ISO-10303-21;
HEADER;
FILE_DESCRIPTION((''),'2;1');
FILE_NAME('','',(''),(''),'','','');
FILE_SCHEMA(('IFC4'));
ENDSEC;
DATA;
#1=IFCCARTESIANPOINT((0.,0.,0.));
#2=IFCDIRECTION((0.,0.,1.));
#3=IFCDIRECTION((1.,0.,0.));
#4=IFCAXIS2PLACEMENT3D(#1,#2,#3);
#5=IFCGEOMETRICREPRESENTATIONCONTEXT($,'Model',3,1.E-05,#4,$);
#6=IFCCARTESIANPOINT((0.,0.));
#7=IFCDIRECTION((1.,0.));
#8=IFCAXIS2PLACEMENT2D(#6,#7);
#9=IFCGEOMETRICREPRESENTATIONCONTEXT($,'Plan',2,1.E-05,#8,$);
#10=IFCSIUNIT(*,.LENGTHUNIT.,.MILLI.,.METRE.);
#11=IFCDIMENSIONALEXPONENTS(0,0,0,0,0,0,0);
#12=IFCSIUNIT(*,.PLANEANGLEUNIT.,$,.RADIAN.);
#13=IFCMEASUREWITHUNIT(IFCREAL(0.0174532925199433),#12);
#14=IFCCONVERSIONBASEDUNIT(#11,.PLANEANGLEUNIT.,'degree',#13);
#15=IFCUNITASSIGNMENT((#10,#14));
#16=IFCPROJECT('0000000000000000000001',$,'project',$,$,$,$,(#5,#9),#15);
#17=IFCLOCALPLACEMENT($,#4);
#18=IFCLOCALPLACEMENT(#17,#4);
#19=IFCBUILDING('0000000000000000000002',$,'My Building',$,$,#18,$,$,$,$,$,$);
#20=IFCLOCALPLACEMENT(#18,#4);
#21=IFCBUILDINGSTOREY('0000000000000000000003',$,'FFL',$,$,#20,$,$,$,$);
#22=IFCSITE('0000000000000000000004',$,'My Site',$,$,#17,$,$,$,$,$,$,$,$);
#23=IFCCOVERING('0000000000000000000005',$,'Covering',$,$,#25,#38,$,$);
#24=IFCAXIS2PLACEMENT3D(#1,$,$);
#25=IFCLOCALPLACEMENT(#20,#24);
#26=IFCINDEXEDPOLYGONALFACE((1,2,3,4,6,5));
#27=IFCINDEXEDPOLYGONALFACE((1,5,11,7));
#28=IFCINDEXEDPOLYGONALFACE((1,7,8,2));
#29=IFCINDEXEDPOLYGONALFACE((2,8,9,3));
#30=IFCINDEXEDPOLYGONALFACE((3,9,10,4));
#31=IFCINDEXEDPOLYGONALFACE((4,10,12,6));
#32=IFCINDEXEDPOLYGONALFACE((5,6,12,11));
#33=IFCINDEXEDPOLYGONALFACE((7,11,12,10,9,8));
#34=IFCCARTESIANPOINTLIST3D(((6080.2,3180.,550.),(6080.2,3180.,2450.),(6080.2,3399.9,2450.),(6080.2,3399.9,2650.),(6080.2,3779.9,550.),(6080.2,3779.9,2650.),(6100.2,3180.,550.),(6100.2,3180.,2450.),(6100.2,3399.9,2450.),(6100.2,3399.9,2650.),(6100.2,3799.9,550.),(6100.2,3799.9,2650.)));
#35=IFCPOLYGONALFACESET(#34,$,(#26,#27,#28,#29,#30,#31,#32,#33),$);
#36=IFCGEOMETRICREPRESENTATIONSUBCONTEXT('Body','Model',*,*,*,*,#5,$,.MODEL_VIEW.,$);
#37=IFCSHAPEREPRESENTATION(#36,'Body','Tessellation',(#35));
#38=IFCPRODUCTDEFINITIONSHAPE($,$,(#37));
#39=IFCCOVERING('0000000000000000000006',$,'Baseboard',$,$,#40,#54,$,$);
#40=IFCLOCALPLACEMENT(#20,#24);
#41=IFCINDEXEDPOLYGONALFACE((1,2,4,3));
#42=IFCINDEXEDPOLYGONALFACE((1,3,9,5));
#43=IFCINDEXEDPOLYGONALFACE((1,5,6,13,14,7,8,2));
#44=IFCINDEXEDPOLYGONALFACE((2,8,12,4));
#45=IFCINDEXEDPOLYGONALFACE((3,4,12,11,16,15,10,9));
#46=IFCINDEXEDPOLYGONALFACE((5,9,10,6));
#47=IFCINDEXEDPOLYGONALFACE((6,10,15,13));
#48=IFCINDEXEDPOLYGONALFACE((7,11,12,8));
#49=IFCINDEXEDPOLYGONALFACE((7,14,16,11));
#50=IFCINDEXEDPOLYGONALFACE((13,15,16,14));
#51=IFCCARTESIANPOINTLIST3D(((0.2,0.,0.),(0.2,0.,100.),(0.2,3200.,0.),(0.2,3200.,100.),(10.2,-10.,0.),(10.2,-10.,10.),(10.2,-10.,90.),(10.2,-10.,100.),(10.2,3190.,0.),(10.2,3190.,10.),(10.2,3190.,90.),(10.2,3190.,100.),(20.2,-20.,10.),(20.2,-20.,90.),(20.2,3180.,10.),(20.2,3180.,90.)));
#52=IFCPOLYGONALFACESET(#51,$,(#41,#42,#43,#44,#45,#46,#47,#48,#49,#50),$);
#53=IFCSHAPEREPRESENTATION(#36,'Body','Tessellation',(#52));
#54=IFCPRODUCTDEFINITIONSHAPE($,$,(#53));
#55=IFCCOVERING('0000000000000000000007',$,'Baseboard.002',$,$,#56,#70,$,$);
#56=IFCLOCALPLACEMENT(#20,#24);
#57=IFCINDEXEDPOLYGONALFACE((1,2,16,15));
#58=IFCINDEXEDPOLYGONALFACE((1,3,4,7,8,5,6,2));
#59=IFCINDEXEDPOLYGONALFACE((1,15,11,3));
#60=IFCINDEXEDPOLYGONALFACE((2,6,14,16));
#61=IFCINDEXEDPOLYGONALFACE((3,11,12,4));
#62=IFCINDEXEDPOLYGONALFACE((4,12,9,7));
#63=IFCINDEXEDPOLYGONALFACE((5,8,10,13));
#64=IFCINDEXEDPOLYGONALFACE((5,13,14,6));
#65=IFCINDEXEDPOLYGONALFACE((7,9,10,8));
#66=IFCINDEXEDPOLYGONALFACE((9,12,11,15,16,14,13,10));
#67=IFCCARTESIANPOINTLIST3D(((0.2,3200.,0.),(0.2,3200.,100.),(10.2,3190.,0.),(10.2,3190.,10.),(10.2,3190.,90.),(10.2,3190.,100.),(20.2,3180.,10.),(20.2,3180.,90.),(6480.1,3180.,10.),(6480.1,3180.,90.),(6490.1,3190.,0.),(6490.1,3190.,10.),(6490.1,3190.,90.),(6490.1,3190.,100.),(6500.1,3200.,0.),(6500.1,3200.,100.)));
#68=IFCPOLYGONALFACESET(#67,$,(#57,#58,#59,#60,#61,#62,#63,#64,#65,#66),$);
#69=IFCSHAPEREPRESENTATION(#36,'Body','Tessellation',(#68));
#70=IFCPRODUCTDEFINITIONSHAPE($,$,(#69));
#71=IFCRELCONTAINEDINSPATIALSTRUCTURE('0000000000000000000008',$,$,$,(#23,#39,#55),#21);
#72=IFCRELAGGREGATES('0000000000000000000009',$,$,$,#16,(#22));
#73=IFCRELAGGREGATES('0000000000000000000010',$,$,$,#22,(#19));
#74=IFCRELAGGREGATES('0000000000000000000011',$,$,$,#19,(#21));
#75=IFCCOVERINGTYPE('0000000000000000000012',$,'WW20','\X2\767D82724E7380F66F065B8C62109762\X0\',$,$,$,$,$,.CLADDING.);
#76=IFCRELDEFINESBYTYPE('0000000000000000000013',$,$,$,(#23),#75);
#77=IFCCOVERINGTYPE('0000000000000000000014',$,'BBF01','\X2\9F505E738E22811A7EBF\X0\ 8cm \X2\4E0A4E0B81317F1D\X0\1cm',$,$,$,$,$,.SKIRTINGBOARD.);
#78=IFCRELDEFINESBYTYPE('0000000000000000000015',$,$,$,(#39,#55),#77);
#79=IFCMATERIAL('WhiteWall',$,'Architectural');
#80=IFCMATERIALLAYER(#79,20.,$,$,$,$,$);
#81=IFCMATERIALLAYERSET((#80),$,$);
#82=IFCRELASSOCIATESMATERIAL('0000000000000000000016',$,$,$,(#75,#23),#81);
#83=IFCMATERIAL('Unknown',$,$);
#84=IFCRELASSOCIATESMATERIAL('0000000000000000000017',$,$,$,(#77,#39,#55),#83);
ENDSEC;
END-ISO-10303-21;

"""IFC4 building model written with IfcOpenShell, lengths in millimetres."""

from ifc_helpers import new_model, entity, si_unit, converted_unit, frame, origin_with_axes, origin_2d_with_axis, place, context, subcontext, project, spatial, line, indexed_curve, outline, extrude, clip, halfspace, material, layer, layer_set, layer_usage, material_profile, profile_set, profile_usage, type_object, element, save


model = new_model("IFC4")

# Units and contexts
model_context = context("Model", 3, precision=1e-05, world=origin_with_axes())
plan_context = context("Plan", 2, precision=1e-05, world=origin_2d_with_axis())
body_context_1 = subcontext(model_context, "Body", "Model", "MODEL_VIEW")
ifc_project = project(units=[si_unit("LENGTHUNIT", "METRE", prefix="MILLI"), converted_unit("PLANEANGLEUNIT", "degree", entity("IfcReal", 0.0174532925199433), si_unit("PLANEANGLEUNIT", "RADIAN"), dimensions=[0, 0, 0, 0, 0, 0, 0])], contexts=[model_context, plan_context])

# Site, building, storey
site_placement = place(None, origin_with_axes())
site = spatial("IfcSite", under=ifc_project, at=site_placement, Name="My Site")
building_placement = place(site_placement, origin_with_axes())
building = spatial("IfcBuilding", under=site, at=building_placement, Name="My Building")
storey_placement = place(building_placement, origin_with_axes())
storey = spatial("IfcBuildingStorey", under=building, at=storey_placement, Name="FFL")

# Covering, opening
ifc_material_1 = material(Name="WhiteWall", Category="Architectural")
ifc_layer_1 = layer(ifc_material_1, 20.0)
ifc_layer_set_1 = layer_set([ifc_layer_1])
covering_type_1 = type_object("IfcCoveringType", Name="WW20", Description="白色乳胶漆完成面", PredefinedType="CLADDING", material=ifc_layer_set_1)
ifc_layer_usage_1 = layer_usage(ifc_layer_set_1, "AXIS2", "NEGATIVE", 0.0)
covering_1_placement = place(storey_placement, frame((6100.2, 3799.9, 550.0), z_axis=(0.0, 0.0, 1.0), x_axis=(-0.000001, -1.0, 0.0)))
covering_1 = element("IfcCovering", 1, at=covering_1_placement, inside=storey, type_object=covering_type_1, material=ifc_layer_usage_1, Name="Covering", context=body_context_1, shape_type="SweptSolid", body=[
    extrude(outline(indexed_curve([(20.0, -20.0), (0.0, 0.0), (620.0, 0.0), (620.0, -20.0)], segments=[line(1, 2, 3, 4, 1)])), origin_with_axes(), (0.0, 0.0, 1.0), 2100.0),
])
opening_1_placement = place(covering_1_placement, frame((620.0, 120.0, 1900.0), z_axis=(0.000001, -1.0, 0.0), x_axis=(0.0, 0.0, 1.0)))
element("IfcOpeningElement", 2, at=opening_1_placement, cuts=covering_1, PredefinedType="OPENING", context=body_context_1, shape_type="SweptSolid", body=[
    extrude(outline(indexed_curve([(0.0, 220.0), (500.0, 220.0), (500.0, -100.0), (0.0, -100.0), (0.0, 220.0)])), origin_with_axes(), (0.0, 0.0, 1.0), 500.0),
])

# Coverings
ifc_material_2 = material(Name="Unknown")
ifc_material_profile = material_profile(ifc_material_2, outline(indexed_curve([(0.0, 100.0), (10.0, 100.0), (10.0, 90.0), (20.0, 90.0), (20.0, 10.0), (10.0, 10.0), (10.0, 0.0), (0.0, 0.0), (0.0, 100.0)])))
ifc_profile_set = profile_set([ifc_material_profile])
ifc_profile_usage_1 = profile_usage(ifc_profile_set, cardinal=5)
covering_type_2 = type_object("IfcCoveringType", Name="BBF01", Description="齐平踢脚线 8cm 上下脱缝1cm", PredefinedType="SKIRTINGBOARD", material=ifc_profile_set)
covering_2_placement = place(storey_placement, frame((0.2, 3200.0, 0.0), z_axis=(0.0, -1.0, 0.0), x_axis=(1.0, 0.0, 0.0)))
element("IfcCovering", 3, at=covering_2_placement, inside=storey, type_object=covering_type_2, material=ifc_profile_usage_1, Name="Baseboard", context=body_context_1, shape_type="Clipping", body=[
    clip(clip(extrude(outline(indexed_curve([(0.0, 100.0), (10.0, 100.0), (10.0, 90.0), (20.0, 90.0), (20.0, 10.0), (10.0, 10.0), (10.0, 0.0), (0.0, 0.0), (0.0, 100.0)])), origin_with_axes(), (0.0, 0.0, 1.0), 3220.0), halfspace(frame((0.0, 0.0, 0.0), z_axis=(0.707107, 0.0, -0.707107), x_axis=(0.0, -1.0, 0.0)), False)), halfspace(frame((20.0, 0.0, 3220.0), z_axis=(-0.707107, 0.0, 0.707107), x_axis=(0.0, 1.0, 0.0)), False)),
])
ifc_profile_usage_2 = profile_usage(ifc_profile_set, cardinal=5)
covering_3_placement = place(storey_placement, frame((6500.1, 3200.0, 0.0), z_axis=(-1.0, 0.0, 0.0), x_axis=(0.0, -1.0, 0.0)))
element("IfcCovering", 4, at=covering_3_placement, inside=storey, type_object=covering_type_2, material=ifc_profile_usage_2, Name="Baseboard.002", context=body_context_1, shape_type="Clipping", body=[
    clip(clip(extrude(outline(indexed_curve([(0.0, 100.0), (10.0, 100.0), (10.0, 90.0), (20.0, 90.0), (20.0, 10.0), (10.0, 10.0), (10.0, 0.0), (0.0, 0.0), (0.0, 100.0)])), origin_with_axes(), (0.0, 0.0, 1.0), 6499.9), halfspace(frame((0.0, 0.0, 0.0), z_axis=(0.707107, 0.0, -0.707107), x_axis=(0.0, -1.0, 0.0)), False)), halfspace(frame((0.0, 0.0, 6499.9), z_axis=(0.707107, 0.0, 0.707106), x_axis=(0.0, -1.0, 0.0)), False)),
])

save(model, "model.ifc")
